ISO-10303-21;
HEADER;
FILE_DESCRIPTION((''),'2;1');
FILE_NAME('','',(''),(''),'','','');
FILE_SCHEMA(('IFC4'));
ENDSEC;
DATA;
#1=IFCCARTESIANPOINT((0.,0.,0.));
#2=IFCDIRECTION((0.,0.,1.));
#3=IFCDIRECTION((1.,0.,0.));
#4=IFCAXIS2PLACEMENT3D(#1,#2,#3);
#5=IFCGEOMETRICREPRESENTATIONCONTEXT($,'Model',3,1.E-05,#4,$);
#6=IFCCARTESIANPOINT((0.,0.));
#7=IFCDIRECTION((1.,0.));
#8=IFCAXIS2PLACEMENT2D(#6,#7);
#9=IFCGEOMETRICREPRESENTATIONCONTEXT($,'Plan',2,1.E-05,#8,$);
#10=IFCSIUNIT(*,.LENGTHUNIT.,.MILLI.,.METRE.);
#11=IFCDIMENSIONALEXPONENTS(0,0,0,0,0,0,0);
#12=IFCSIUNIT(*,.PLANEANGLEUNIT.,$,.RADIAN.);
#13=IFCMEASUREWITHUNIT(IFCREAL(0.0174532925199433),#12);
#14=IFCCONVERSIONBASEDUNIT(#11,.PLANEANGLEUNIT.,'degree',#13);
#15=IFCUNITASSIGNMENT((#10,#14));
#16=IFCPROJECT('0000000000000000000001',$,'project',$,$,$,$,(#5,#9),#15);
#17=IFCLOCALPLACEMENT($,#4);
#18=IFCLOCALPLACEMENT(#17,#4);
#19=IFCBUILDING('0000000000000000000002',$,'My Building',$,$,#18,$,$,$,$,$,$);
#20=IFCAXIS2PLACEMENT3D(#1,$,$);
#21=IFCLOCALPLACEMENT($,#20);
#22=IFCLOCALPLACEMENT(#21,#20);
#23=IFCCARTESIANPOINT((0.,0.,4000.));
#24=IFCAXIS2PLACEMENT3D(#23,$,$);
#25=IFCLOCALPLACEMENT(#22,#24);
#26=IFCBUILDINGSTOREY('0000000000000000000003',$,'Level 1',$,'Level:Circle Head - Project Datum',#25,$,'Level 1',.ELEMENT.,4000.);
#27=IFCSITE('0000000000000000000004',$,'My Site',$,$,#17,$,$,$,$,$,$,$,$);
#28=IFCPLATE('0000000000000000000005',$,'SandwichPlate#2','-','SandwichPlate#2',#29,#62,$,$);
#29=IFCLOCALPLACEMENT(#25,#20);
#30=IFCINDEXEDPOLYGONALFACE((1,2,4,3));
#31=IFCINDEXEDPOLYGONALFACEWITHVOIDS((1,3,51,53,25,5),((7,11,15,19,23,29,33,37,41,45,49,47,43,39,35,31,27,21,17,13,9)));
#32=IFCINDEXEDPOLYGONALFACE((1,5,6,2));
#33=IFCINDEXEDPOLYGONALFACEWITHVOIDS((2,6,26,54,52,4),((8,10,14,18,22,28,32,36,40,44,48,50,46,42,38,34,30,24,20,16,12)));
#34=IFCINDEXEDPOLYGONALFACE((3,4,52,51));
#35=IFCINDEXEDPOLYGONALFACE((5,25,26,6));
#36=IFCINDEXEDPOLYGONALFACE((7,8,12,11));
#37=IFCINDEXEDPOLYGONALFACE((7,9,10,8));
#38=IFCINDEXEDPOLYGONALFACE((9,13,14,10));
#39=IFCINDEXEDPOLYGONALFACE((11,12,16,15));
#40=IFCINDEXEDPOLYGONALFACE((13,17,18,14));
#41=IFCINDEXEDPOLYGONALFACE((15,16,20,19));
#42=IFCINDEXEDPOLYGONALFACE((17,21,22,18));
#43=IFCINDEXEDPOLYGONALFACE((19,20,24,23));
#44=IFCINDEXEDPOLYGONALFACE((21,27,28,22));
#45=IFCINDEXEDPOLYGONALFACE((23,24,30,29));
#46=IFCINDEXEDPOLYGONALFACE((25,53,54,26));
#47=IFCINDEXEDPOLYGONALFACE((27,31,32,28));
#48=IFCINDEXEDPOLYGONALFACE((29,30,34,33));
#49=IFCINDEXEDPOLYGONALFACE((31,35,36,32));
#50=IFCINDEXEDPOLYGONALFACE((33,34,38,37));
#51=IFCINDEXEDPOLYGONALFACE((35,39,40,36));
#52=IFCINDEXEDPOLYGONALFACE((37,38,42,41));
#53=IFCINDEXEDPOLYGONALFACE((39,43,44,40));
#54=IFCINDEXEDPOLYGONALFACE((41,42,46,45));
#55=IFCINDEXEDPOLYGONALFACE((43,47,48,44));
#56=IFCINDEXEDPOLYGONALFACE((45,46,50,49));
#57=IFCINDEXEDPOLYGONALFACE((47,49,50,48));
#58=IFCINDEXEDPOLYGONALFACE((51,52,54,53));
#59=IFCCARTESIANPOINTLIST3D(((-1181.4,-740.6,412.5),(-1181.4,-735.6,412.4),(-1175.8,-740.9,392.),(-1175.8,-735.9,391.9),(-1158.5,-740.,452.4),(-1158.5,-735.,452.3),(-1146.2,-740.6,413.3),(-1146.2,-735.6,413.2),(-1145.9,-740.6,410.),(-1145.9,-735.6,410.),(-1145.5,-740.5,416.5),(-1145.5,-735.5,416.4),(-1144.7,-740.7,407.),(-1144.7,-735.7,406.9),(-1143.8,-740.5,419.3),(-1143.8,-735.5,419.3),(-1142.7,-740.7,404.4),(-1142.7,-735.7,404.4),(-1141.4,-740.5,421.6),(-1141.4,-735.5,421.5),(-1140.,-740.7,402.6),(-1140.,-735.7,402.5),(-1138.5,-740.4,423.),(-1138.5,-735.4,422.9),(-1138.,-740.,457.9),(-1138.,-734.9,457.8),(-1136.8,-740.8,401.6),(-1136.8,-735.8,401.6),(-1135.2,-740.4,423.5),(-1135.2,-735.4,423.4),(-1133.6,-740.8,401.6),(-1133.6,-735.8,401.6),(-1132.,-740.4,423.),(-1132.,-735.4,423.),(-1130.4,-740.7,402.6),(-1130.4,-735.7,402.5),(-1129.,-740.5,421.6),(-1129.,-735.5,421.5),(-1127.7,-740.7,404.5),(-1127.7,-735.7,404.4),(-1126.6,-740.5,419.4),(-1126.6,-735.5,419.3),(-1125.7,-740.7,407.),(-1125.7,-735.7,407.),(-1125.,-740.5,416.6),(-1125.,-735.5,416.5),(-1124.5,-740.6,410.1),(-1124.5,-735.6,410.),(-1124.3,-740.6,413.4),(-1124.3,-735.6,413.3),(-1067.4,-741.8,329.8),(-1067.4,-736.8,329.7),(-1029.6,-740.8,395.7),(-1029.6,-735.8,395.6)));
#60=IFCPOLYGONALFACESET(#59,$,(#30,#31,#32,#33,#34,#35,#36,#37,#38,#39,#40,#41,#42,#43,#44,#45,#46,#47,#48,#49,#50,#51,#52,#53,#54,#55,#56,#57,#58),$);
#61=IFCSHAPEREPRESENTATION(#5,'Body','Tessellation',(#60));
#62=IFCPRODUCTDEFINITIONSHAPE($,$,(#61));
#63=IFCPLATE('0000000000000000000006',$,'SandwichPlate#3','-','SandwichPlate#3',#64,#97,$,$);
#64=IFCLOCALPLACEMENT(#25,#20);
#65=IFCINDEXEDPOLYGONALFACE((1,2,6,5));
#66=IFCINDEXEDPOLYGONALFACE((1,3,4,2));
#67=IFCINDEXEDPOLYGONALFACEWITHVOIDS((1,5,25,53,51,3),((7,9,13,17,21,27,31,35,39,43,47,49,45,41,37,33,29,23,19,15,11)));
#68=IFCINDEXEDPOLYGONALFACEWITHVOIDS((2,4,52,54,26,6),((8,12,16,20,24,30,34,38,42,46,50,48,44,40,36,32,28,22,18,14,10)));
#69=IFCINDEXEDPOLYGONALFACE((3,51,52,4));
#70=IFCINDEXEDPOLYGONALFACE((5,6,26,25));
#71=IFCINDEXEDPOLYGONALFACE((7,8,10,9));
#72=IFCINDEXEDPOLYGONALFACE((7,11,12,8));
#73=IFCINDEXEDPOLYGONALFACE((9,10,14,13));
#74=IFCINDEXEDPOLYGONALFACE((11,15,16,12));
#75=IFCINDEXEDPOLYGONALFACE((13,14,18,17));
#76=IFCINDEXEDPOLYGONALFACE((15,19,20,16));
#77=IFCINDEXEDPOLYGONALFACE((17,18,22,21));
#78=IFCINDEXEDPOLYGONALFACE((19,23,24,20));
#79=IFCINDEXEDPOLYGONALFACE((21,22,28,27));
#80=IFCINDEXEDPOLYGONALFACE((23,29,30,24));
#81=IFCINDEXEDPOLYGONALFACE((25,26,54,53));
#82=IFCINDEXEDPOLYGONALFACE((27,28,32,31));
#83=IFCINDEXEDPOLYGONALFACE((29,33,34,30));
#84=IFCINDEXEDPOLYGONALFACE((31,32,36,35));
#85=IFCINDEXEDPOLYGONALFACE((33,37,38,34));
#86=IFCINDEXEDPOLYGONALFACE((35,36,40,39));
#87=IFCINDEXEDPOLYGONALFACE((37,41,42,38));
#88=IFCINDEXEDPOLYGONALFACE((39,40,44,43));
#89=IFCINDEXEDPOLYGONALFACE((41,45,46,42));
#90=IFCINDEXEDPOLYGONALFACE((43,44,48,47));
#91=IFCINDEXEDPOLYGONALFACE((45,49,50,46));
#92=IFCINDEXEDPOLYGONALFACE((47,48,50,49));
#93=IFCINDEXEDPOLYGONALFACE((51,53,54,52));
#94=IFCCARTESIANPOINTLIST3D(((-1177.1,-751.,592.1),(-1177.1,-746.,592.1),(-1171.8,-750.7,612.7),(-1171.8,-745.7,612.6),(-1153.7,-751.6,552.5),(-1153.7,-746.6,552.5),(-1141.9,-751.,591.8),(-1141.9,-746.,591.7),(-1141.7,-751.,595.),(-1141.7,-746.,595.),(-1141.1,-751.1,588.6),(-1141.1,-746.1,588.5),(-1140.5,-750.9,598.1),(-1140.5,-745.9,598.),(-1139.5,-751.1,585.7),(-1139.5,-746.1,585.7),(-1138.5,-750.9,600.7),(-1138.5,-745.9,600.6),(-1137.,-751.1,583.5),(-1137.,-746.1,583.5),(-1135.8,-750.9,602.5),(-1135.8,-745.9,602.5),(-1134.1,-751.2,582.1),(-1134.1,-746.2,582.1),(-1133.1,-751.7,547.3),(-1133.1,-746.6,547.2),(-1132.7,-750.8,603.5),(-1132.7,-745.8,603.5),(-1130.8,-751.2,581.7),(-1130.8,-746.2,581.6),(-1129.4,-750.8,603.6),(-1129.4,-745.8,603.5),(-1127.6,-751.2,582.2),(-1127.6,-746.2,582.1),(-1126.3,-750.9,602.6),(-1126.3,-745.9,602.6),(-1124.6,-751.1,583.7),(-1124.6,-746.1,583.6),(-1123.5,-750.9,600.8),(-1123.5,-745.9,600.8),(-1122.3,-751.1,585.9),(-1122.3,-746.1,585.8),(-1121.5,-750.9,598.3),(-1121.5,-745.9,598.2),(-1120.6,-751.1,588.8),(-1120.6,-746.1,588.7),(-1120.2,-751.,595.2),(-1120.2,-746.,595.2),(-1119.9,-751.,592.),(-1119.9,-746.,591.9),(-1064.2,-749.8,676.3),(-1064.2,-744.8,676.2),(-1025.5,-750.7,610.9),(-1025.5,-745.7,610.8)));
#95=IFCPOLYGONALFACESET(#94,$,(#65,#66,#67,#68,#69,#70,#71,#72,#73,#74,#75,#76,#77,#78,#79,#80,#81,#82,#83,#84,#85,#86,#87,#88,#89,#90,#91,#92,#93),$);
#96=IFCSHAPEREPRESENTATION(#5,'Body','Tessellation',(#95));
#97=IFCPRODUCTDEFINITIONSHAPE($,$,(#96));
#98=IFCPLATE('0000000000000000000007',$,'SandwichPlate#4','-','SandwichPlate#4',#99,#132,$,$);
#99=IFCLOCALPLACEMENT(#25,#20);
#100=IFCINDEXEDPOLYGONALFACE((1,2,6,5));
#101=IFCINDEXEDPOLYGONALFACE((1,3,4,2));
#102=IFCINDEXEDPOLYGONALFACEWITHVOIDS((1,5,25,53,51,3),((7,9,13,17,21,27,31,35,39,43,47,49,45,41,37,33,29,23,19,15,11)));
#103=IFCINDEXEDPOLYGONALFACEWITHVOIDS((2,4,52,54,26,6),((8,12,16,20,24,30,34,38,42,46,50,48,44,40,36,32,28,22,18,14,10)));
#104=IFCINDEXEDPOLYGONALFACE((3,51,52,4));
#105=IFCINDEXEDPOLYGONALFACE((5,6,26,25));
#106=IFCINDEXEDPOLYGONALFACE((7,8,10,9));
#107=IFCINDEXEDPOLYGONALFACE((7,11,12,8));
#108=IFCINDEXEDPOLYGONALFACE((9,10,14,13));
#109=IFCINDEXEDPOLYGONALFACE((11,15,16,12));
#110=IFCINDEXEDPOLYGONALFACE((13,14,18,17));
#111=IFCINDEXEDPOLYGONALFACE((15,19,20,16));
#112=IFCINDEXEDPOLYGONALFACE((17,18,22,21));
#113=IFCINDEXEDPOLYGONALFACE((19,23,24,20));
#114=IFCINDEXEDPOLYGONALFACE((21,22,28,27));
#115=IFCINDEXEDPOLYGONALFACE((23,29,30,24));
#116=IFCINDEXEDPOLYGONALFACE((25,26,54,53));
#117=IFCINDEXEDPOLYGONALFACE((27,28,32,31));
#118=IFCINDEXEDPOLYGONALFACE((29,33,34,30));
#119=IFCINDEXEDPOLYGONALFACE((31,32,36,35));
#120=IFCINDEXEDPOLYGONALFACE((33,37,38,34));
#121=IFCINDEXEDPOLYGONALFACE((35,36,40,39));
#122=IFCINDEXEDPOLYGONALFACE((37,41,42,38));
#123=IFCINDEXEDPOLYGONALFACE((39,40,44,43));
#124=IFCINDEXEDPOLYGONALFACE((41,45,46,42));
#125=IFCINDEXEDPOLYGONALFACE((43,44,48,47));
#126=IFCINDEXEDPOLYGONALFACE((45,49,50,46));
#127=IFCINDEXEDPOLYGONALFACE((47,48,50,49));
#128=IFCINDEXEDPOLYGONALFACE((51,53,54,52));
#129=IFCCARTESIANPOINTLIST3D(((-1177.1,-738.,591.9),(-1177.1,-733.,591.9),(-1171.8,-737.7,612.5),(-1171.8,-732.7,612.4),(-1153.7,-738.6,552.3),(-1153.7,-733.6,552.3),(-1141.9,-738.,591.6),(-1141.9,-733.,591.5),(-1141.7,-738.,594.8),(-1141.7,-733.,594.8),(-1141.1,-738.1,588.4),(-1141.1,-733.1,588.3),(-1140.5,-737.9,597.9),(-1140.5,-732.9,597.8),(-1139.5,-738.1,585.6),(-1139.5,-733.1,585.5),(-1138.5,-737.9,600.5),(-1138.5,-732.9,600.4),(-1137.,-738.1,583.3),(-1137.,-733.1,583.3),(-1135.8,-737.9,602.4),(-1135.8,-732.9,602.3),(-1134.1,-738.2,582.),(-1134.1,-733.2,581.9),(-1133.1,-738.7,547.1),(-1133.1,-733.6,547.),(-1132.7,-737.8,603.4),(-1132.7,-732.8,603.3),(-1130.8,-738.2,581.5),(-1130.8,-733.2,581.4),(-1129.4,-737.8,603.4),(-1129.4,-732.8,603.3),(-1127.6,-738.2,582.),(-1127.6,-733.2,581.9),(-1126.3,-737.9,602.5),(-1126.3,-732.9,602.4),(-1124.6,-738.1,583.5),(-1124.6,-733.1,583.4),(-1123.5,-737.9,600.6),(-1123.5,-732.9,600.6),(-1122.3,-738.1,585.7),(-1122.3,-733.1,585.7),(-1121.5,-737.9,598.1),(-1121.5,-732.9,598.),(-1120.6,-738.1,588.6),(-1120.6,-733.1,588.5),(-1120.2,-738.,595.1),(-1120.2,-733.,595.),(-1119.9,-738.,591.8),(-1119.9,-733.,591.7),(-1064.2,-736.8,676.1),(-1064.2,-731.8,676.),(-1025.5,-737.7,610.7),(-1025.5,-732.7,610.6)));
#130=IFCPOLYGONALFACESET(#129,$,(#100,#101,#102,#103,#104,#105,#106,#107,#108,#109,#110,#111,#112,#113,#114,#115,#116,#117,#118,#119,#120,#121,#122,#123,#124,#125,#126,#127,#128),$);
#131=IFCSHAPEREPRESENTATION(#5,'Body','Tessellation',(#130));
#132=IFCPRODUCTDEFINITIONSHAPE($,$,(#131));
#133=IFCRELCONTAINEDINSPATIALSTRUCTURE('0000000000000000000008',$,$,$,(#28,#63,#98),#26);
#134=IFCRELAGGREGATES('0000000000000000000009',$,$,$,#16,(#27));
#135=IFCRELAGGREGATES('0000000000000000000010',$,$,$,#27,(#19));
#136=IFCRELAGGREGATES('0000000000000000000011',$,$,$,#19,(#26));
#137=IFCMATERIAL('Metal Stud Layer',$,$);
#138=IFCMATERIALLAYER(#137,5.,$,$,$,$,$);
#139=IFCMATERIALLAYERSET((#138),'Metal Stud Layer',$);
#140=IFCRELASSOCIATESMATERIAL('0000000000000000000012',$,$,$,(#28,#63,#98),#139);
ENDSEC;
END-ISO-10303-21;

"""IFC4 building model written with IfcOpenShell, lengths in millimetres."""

from ifc_helpers import new_model, entity, si_unit, converted_unit, frame, origin, origin_with_axes, origin_2d_with_axis, place, context, project, spatial, polyline, circle, outline, extrude, material, layer, layer_set, element, save


model = new_model("IFC4")

# Units and contexts
model_context = context("Model", 3, precision=1e-05, world=origin_with_axes())
plan_context = context("Plan", 2, precision=1e-05, world=origin_2d_with_axis())
ifc_project = project(units=[si_unit("LENGTHUNIT", "METRE", prefix="MILLI"), converted_unit("PLANEANGLEUNIT", "degree", entity("IfcReal", 0.0174532925199433), si_unit("PLANEANGLEUNIT", "RADIAN"), dimensions=[0, 0, 0, 0, 0, 0, 0])], contexts=[model_context, plan_context])

# Site, building, storey
site_placement = place(None, origin_with_axes())
site = spatial("IfcSite", under=ifc_project, at=site_placement, Name="My Site")
building_placement = place(site_placement, origin_with_axes())
building = spatial("IfcBuilding", under=site, at=building_placement, Name="My Building")
placement_1 = place(None, origin())
placement_2 = place(placement_1, origin())
storey_placement = place(placement_2, frame((0.0, 0.0, 4000.0)))
storey = spatial("IfcBuildingStorey", under=building, at=storey_placement, Name="Level 1", ObjectType="Level:Circle Head - Project Datum", LongName="Level 1", CompositionType="ELEMENT", Elevation=4000.0)

# Plates, openings
ifc_material_1 = material(Name="Metal Stud Layer")
ifc_layer_1 = layer(ifc_material_1, 5.0)
ifc_layer_set_1 = layer_set([ifc_layer_1], Name="Metal Stud Layer")
plate_1_placement = place(storey_placement, frame((-1188.8, -740.8, 399.5), z_axis=(0.0, 0.999896, -0.014432), x_axis=(0.497964, 0.012516, 0.867107)))
plate_1 = element("IfcPlate", 1, at=plate_1_placement, inside=storey, material=ifc_layer_set_1, Name="SandwichPlate#2", Description="-", ObjectType="SandwichPlate#2", context=model_context, shape_type="SweptSolid", body=[
    extrude(outline(polyline([(0.0, 0.0), (76.0, 0.0), (76.0, 140.0), (0.0, 140.0), (0.0, 0.0)])), origin_with_axes(), (0.0, 0.0, 1.0), 5.0),
])
opening_1_placement = place(plate_1_placement, frame((38.0, 40.0, -0.5), z_axis=(0.0, 0.0, 1.0), x_axis=(0.0, 1.0, 0.0)))
element("IfcOpeningElement", 2, at=opening_1_placement, cuts=plate_1, ObjectType="Opening", context=model_context, shape_type="SweptSolid", body=[
    extrude(circle(Radius=11.0, at=origin_2d_with_axis()), origin(), (0.0, 0.0, 1.0), 6.0),
])
opening_2_placement = place(plate_1_placement, frame((0.0, 0.0, 0.0), z_axis=(0.0, 0.0, 1.0), x_axis=(1.0, 0.0, 0.0)))
element("IfcOpeningElement", 3, at=opening_2_placement, cuts=plate_1, ObjectType="Opening", context=model_context, shape_type="SweptSolid", body=[
    extrude(outline(polyline([(0.0, 0.0), (15.0, 0.0), (0.0, 15.0), (0.0, 0.0)])), origin(), (0.0, 0.0, 1.0), 5.0),
])
opening_3_placement = place(plate_1_placement, frame((0.0, 0.0, 0.0), z_axis=(0.0, 0.0, 1.0), x_axis=(1.0, 0.0, 0.0)))
element("IfcOpeningElement", 4, at=opening_3_placement, cuts=plate_1, ObjectType="Opening", context=model_context, shape_type="SweptSolid", body=[
    extrude(outline(polyline([(76.0, 0.0), (76.0, 15.0), (61.0, 0.0), (76.0, 0.0)])), origin(), (0.0, 0.0, 1.0), 5.0),
])
plate_2_placement = place(storey_placement, frame((-1146.0, -751.8, 539.6), z_axis=(0.0, 0.999896, -0.014432), x_axis=(-0.508911, 0.012424, 0.860729)))
plate_2 = element("IfcPlate", 5, at=plate_2_placement, inside=storey, material=ifc_layer_set_1, Name="SandwichPlate#3", Description="-", ObjectType="SandwichPlate#3", context=model_context, shape_type="SweptSolid", body=[
    extrude(outline(polyline([(0.0, 0.0), (76.0, 0.0), (76.0, 140.0), (0.0, 140.0), (0.0, 0.0)])), origin_with_axes(), (0.0, 0.0, 1.0), 5.0),
])
opening_4_placement = place(plate_2_placement, frame((38.0, 40.0, -0.5), z_axis=(0.0, 0.0, 1.0), x_axis=(0.0, 1.0, 0.0)))
element("IfcOpeningElement", 6, at=opening_4_placement, cuts=plate_2, ObjectType="Opening", context=model_context, shape_type="SweptSolid", body=[
    extrude(circle(Radius=11.0, at=origin_2d_with_axis()), origin(), (0.0, 0.0, 1.0), 6.0),
])
opening_5_placement = place(plate_2_placement, frame((0.0, 0.0, 0.0), z_axis=(0.0, 0.0, 1.0), x_axis=(1.0, 0.0, 0.0)))
element("IfcOpeningElement", 7, at=opening_5_placement, cuts=plate_2, ObjectType="Opening", context=model_context, shape_type="SweptSolid", body=[
    extrude(outline(polyline([(0.0, 0.0), (15.0, 0.0), (0.0, 15.0), (0.0, 0.0)])), origin(), (0.0, 0.0, 1.0), 5.0),
])
opening_6_placement = place(plate_2_placement, frame((0.0, 0.0, 0.0), z_axis=(0.0, 0.0, 1.0), x_axis=(1.0, 0.0, 0.0)))
element("IfcOpeningElement", 8, at=opening_6_placement, cuts=plate_2, ObjectType="Opening", context=model_context, shape_type="SweptSolid", body=[
    extrude(outline(polyline([(76.0, 0.0), (76.0, 15.0), (61.0, 0.0), (76.0, 0.0)])), origin(), (0.0, 0.0, 1.0), 5.0),
])
plate_3_placement = place(storey_placement, frame((-1146.0, -738.8, 539.4), z_axis=(0.0, 0.999896, -0.014432), x_axis=(-0.508911, 0.012424, 0.860729)))
plate_3 = element("IfcPlate", 9, at=plate_3_placement, inside=storey, material=ifc_layer_set_1, Name="SandwichPlate#4", Description="-", ObjectType="SandwichPlate#4", context=model_context, shape_type="SweptSolid", body=[
    extrude(outline(polyline([(0.0, 0.0), (76.0, 0.0), (76.0, 140.0), (0.0, 140.0), (0.0, 0.0)])), origin_with_axes(), (0.0, 0.0, 1.0), 5.0),
])
opening_7_placement = place(plate_3_placement, frame((38.0, 40.0, -0.5), z_axis=(0.0, 0.0, 1.0), x_axis=(0.0, 1.0, 0.0)))
element("IfcOpeningElement", 10, at=opening_7_placement, cuts=plate_3, ObjectType="Opening", context=model_context, shape_type="SweptSolid", body=[
    extrude(circle(Radius=11.0, at=origin_2d_with_axis()), origin(), (0.0, 0.0, 1.0), 6.0),
])
opening_8_placement = place(plate_3_placement, frame((0.0, 0.0, 0.0), z_axis=(0.0, 0.0, 1.0), x_axis=(1.0, 0.0, 0.0)))
element("IfcOpeningElement", 11, at=opening_8_placement, cuts=plate_3, ObjectType="Opening", context=model_context, shape_type="SweptSolid", body=[
    extrude(outline(polyline([(0.0, 0.0), (15.0, 0.0), (0.0, 15.0), (0.0, 0.0)])), origin(), (0.0, 0.0, 1.0), 5.0),
])
opening_9_placement = place(plate_3_placement, frame((0.0, 0.0, 0.0), z_axis=(0.0, 0.0, 1.0), x_axis=(1.0, 0.0, 0.0)))
element("IfcOpeningElement", 12, at=opening_9_placement, cuts=plate_3, ObjectType="Opening", context=model_context, shape_type="SweptSolid", body=[
    extrude(outline(polyline([(76.0, 0.0), (76.0, 15.0), (61.0, 0.0), (76.0, 0.0)])), origin(), (0.0, 0.0, 1.0), 5.0),
])

save(model, "model.ifc")
